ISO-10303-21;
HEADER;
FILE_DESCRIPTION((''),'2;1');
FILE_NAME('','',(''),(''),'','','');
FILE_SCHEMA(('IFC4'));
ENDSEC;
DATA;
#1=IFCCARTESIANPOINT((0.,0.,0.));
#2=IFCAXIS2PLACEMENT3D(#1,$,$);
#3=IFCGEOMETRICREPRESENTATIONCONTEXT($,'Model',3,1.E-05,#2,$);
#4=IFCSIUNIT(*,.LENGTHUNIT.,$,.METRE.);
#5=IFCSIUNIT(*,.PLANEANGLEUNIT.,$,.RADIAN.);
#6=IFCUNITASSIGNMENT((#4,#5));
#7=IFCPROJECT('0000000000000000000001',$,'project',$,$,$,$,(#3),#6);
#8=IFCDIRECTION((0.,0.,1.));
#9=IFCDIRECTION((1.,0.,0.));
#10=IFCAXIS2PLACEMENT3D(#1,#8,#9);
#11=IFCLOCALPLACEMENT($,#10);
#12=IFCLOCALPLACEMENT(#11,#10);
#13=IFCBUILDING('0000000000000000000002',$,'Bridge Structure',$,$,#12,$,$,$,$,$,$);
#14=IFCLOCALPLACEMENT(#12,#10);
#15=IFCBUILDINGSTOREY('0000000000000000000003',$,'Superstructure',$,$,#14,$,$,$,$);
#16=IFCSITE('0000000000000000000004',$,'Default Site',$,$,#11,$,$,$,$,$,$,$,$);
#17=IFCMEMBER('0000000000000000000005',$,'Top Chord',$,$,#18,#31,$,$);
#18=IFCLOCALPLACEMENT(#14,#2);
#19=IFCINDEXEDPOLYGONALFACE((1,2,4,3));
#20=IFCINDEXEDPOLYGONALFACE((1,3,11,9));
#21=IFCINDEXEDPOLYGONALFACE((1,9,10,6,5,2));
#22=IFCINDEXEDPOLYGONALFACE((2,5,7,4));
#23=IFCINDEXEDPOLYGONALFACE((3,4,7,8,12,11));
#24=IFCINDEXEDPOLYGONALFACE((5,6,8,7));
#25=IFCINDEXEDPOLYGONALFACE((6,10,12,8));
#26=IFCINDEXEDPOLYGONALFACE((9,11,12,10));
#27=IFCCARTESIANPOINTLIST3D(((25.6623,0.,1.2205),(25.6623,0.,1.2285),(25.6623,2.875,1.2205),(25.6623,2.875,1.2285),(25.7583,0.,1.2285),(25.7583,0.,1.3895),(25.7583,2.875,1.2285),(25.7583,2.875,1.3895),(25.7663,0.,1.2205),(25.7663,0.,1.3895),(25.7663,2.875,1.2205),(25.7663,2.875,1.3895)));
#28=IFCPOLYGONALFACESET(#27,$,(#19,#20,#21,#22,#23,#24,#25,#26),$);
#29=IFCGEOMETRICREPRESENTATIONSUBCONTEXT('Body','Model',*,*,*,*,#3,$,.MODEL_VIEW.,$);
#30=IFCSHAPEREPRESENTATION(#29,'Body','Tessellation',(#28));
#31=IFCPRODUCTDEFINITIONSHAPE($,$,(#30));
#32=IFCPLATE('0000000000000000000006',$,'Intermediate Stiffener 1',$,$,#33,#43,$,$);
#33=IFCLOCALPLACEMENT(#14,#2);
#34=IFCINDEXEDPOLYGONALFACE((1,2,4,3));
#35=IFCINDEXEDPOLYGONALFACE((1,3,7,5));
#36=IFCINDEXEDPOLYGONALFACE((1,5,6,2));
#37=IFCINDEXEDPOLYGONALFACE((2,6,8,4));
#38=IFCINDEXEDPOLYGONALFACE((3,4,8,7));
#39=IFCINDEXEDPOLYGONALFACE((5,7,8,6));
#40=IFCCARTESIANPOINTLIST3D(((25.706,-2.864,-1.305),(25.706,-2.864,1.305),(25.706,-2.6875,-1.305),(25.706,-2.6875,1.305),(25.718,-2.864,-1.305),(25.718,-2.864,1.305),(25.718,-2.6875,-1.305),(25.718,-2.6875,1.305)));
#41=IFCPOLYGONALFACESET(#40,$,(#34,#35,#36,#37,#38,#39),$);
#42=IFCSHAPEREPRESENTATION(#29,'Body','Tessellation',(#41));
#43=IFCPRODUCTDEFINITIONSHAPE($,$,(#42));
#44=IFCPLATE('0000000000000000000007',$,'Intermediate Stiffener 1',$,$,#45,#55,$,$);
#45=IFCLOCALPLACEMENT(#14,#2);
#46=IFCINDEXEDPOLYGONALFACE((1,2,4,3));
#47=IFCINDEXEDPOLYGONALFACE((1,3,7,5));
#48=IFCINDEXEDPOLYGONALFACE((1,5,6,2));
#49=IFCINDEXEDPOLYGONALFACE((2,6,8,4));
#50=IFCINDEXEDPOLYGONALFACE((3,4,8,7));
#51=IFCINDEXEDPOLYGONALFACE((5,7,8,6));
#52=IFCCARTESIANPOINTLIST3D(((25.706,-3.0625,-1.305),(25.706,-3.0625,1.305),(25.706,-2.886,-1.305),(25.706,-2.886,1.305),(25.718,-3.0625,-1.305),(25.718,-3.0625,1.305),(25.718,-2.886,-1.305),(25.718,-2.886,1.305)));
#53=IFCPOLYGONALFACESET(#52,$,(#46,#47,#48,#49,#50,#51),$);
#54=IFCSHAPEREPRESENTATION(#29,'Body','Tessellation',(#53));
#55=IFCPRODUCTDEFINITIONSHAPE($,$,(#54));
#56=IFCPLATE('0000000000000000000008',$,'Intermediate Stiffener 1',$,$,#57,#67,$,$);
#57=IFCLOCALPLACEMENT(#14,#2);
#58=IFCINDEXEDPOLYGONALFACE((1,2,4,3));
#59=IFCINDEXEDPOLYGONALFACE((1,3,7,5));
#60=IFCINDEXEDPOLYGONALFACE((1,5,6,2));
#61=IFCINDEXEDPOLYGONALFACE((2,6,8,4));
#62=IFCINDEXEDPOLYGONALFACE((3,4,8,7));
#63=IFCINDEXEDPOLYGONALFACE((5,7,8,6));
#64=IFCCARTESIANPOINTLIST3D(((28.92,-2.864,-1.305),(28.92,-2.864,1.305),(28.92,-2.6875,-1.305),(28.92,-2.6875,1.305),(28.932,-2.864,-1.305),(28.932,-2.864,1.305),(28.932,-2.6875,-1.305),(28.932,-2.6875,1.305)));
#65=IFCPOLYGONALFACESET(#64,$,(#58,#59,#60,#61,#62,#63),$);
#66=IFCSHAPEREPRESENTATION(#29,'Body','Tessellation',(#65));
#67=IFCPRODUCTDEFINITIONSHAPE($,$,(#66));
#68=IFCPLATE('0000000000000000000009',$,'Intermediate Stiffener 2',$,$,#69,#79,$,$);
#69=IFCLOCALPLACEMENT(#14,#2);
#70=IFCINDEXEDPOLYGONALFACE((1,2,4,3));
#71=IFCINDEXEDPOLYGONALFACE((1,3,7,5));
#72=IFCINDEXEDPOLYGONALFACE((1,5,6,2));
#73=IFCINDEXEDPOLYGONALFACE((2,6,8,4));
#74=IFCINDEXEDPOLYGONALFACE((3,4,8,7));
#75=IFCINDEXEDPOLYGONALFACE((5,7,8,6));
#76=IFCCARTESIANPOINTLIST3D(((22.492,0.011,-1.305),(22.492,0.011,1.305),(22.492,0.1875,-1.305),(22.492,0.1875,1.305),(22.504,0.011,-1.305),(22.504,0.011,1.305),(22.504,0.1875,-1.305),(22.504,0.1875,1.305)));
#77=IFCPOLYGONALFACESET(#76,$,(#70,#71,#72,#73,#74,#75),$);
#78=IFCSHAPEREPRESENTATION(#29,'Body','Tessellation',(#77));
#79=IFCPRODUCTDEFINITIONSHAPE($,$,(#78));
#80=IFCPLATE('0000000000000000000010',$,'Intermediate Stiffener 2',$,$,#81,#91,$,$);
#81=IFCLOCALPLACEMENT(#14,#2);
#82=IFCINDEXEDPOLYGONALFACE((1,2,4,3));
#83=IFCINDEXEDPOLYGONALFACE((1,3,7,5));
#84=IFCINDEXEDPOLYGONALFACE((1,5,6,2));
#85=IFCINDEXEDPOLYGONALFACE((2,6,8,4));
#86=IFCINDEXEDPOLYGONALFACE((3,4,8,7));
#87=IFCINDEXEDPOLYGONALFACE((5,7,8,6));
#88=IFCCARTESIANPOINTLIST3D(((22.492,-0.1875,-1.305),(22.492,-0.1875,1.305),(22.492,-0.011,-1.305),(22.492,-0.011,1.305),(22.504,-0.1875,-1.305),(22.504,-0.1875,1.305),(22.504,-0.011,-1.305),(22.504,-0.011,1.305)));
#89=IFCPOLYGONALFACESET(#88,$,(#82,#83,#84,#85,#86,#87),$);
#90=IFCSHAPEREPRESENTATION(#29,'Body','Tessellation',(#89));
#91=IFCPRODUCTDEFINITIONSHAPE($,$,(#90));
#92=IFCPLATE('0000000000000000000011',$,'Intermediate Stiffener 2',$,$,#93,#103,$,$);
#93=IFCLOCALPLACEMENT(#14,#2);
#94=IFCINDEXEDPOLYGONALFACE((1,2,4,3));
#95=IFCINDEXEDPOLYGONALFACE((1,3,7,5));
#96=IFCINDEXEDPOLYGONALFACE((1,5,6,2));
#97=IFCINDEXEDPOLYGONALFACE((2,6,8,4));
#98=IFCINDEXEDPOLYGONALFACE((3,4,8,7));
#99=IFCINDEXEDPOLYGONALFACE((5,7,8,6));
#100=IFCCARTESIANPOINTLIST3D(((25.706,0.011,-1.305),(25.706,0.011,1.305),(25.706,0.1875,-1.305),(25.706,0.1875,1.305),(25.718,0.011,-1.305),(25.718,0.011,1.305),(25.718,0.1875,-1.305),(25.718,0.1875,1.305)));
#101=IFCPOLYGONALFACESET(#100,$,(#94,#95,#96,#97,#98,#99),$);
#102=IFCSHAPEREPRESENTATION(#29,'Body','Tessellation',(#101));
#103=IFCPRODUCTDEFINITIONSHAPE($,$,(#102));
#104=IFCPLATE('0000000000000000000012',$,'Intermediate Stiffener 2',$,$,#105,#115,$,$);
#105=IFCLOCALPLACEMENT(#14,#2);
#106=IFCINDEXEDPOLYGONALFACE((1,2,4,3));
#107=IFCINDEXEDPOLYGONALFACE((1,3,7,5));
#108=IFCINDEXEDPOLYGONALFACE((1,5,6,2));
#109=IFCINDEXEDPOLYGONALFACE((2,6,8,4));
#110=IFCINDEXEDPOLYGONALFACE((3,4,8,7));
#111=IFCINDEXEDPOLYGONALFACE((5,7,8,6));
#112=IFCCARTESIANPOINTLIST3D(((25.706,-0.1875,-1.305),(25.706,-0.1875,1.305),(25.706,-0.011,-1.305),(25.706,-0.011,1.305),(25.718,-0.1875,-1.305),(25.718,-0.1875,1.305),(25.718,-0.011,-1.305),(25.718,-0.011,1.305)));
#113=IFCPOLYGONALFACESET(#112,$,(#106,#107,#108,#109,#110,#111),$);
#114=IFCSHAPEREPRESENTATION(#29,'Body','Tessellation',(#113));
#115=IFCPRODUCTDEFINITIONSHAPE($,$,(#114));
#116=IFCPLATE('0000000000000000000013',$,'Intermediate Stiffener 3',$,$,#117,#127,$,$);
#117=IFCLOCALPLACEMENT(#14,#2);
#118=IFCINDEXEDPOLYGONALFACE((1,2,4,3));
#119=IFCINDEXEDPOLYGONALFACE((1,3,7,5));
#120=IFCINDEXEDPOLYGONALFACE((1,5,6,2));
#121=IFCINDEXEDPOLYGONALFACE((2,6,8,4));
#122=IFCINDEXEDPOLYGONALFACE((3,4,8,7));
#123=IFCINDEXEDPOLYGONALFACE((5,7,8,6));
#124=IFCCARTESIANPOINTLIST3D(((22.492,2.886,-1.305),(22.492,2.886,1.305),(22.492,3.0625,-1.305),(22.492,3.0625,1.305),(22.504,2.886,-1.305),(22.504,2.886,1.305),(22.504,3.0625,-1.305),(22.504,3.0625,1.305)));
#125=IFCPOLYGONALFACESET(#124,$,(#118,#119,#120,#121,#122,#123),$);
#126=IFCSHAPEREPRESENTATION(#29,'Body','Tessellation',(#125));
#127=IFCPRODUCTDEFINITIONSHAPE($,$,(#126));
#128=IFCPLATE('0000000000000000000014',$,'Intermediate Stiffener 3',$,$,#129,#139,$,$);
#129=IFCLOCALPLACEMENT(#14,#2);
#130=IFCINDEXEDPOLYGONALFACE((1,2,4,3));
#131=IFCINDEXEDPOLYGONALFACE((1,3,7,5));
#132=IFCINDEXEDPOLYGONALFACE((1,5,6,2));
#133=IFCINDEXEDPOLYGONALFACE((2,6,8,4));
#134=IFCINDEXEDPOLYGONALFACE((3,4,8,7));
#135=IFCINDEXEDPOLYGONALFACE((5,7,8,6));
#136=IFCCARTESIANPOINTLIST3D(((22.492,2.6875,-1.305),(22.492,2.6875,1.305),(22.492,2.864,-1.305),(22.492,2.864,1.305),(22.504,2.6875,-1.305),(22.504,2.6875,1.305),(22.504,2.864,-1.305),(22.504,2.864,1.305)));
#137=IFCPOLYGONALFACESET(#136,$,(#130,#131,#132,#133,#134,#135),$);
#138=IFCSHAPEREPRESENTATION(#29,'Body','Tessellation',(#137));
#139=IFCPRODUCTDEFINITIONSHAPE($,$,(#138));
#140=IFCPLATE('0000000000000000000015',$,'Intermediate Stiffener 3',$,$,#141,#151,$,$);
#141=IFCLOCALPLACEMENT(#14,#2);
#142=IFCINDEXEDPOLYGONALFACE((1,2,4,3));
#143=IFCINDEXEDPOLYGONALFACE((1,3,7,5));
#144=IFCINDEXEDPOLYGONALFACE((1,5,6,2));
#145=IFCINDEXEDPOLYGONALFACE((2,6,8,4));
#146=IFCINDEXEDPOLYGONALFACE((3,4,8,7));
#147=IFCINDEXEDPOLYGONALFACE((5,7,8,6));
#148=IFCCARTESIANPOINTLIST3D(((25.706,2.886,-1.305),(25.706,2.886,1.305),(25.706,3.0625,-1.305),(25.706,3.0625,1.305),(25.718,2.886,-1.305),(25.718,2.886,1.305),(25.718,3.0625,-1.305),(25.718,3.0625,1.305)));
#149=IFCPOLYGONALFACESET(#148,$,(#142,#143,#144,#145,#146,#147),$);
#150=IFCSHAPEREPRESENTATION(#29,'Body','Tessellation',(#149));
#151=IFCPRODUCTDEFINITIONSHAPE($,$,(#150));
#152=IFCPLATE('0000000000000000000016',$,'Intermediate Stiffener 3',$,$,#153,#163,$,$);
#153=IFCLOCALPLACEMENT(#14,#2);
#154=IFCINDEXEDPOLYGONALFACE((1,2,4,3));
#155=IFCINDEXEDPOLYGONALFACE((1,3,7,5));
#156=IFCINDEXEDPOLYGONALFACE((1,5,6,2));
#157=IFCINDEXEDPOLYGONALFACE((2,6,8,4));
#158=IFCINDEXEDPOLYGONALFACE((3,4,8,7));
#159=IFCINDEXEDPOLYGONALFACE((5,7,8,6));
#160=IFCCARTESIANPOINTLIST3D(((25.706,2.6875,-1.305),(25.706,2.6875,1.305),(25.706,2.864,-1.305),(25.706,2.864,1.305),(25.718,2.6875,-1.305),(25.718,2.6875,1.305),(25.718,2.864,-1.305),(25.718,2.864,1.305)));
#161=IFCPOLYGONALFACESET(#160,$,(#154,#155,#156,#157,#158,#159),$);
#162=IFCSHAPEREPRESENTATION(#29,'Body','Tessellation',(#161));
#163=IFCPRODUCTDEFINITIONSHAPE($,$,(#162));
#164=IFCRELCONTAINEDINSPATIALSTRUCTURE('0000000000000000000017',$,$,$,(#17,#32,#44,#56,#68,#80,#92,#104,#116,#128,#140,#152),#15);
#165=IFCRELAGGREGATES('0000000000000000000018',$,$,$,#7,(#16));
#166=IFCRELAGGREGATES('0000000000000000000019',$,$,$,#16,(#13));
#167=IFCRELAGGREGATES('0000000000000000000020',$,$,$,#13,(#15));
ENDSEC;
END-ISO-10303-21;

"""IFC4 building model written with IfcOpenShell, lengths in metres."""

from ifc_helpers import new_model, si_unit, frame, origin, origin_with_axes, origin_2d_with_axis, place, context, subcontext, project, spatial, rectangle, l_section, extrude, element, save


model = new_model("IFC4")

# Units and contexts
model_context = context("Model", 3, precision=1e-05, world=origin())
body_context = subcontext(model_context, "Body", "Model", "MODEL_VIEW")
ifc_project = project(units=[si_unit("LENGTHUNIT", "METRE"), si_unit("PLANEANGLEUNIT", "RADIAN")], contexts=[model_context])

# Site, building, storey
site_placement = place(None, origin_with_axes())
site = spatial("IfcSite", under=ifc_project, at=site_placement, Name="Default Site")
building_placement = place(site_placement, origin_with_axes())
building = spatial("IfcBuilding", under=site, at=building_placement, Name="Bridge Structure")
storey_placement = place(building_placement, origin_with_axes())
storey = spatial("IfcBuildingStorey", under=building, at=storey_placement, Name="Superstructure")

# Member
for number, where, z_axis, x_axis, name in (
    (1, (25.7143, 0.0, 1.305), (0.0, 1.0, 0.0), (-1.0, 0.0, 0.0), "Top Chord"),
):
    element("IfcMember", number, at=place(storey_placement, frame(where, z_axis=z_axis, x_axis=x_axis)), inside=storey, Name=name, context=body_context, shape_type="SweptSolid", body=[
        extrude(l_section(Depth=0.169, Width=0.104, Thickness=0.008, at=origin_2d_with_axis()), origin_with_axes(), (0.0, 0.0, 1.0), 2.875),
    ])

# Plates
for number, where, z_axis, x_axis, name in (
    (2, (25.712, -2.7757, -1.305), (0.0, 0.0, 1.0), (1.0, 0.0, 0.0), "Intermediate Stiffener 1"),
    (3, (25.712, -2.9743, -1.305), (0.0, 0.0, 1.0), (1.0, 0.0, 0.0), "Intermediate Stiffener 1"),
    (4, (28.926, -2.7757, -1.305), (0.0, 0.0, 1.0), (1.0, 0.0, 0.0), "Intermediate Stiffener 1"),
    (5, (22.498, 0.0993, -1.305), (0.0, 0.0, 1.0), (1.0, 0.0, 0.0), "Intermediate Stiffener 2"),
    (6, (22.498, -0.0993, -1.305), (0.0, 0.0, 1.0), (1.0, 0.0, 0.0), "Intermediate Stiffener 2"),
    (7, (25.712, 0.0993, -1.305), (0.0, 0.0, 1.0), (1.0, 0.0, 0.0), "Intermediate Stiffener 2"),
    (8, (25.712, -0.0993, -1.305), (0.0, 0.0, 1.0), (1.0, 0.0, 0.0), "Intermediate Stiffener 2"),
    (9, (22.498, 2.9743, -1.305), (0.0, 0.0, 1.0), (1.0, 0.0, 0.0), "Intermediate Stiffener 3"),
    (10, (22.498, 2.7757, -1.305), (0.0, 0.0, 1.0), (1.0, 0.0, 0.0), "Intermediate Stiffener 3"),
    (11, (25.712, 2.9743, -1.305), (0.0, 0.0, 1.0), (1.0, 0.0, 0.0), "Intermediate Stiffener 3"),
    (12, (25.712, 2.7757, -1.305), (0.0, 0.0, 1.0), (1.0, 0.0, 0.0), "Intermediate Stiffener 3"),
):
    element("IfcPlate", number, at=place(storey_placement, frame(where, z_axis=z_axis, x_axis=x_axis)), inside=storey, Name=name, context=body_context, shape_type="SweptSolid", body=[
        extrude(rectangle(XDim=0.012, YDim=0.1765, at=origin_2d_with_axis()), origin_with_axes(), (0.0, 0.0, 1.0), 2.61),
    ])

save(model, "model.ifc")
